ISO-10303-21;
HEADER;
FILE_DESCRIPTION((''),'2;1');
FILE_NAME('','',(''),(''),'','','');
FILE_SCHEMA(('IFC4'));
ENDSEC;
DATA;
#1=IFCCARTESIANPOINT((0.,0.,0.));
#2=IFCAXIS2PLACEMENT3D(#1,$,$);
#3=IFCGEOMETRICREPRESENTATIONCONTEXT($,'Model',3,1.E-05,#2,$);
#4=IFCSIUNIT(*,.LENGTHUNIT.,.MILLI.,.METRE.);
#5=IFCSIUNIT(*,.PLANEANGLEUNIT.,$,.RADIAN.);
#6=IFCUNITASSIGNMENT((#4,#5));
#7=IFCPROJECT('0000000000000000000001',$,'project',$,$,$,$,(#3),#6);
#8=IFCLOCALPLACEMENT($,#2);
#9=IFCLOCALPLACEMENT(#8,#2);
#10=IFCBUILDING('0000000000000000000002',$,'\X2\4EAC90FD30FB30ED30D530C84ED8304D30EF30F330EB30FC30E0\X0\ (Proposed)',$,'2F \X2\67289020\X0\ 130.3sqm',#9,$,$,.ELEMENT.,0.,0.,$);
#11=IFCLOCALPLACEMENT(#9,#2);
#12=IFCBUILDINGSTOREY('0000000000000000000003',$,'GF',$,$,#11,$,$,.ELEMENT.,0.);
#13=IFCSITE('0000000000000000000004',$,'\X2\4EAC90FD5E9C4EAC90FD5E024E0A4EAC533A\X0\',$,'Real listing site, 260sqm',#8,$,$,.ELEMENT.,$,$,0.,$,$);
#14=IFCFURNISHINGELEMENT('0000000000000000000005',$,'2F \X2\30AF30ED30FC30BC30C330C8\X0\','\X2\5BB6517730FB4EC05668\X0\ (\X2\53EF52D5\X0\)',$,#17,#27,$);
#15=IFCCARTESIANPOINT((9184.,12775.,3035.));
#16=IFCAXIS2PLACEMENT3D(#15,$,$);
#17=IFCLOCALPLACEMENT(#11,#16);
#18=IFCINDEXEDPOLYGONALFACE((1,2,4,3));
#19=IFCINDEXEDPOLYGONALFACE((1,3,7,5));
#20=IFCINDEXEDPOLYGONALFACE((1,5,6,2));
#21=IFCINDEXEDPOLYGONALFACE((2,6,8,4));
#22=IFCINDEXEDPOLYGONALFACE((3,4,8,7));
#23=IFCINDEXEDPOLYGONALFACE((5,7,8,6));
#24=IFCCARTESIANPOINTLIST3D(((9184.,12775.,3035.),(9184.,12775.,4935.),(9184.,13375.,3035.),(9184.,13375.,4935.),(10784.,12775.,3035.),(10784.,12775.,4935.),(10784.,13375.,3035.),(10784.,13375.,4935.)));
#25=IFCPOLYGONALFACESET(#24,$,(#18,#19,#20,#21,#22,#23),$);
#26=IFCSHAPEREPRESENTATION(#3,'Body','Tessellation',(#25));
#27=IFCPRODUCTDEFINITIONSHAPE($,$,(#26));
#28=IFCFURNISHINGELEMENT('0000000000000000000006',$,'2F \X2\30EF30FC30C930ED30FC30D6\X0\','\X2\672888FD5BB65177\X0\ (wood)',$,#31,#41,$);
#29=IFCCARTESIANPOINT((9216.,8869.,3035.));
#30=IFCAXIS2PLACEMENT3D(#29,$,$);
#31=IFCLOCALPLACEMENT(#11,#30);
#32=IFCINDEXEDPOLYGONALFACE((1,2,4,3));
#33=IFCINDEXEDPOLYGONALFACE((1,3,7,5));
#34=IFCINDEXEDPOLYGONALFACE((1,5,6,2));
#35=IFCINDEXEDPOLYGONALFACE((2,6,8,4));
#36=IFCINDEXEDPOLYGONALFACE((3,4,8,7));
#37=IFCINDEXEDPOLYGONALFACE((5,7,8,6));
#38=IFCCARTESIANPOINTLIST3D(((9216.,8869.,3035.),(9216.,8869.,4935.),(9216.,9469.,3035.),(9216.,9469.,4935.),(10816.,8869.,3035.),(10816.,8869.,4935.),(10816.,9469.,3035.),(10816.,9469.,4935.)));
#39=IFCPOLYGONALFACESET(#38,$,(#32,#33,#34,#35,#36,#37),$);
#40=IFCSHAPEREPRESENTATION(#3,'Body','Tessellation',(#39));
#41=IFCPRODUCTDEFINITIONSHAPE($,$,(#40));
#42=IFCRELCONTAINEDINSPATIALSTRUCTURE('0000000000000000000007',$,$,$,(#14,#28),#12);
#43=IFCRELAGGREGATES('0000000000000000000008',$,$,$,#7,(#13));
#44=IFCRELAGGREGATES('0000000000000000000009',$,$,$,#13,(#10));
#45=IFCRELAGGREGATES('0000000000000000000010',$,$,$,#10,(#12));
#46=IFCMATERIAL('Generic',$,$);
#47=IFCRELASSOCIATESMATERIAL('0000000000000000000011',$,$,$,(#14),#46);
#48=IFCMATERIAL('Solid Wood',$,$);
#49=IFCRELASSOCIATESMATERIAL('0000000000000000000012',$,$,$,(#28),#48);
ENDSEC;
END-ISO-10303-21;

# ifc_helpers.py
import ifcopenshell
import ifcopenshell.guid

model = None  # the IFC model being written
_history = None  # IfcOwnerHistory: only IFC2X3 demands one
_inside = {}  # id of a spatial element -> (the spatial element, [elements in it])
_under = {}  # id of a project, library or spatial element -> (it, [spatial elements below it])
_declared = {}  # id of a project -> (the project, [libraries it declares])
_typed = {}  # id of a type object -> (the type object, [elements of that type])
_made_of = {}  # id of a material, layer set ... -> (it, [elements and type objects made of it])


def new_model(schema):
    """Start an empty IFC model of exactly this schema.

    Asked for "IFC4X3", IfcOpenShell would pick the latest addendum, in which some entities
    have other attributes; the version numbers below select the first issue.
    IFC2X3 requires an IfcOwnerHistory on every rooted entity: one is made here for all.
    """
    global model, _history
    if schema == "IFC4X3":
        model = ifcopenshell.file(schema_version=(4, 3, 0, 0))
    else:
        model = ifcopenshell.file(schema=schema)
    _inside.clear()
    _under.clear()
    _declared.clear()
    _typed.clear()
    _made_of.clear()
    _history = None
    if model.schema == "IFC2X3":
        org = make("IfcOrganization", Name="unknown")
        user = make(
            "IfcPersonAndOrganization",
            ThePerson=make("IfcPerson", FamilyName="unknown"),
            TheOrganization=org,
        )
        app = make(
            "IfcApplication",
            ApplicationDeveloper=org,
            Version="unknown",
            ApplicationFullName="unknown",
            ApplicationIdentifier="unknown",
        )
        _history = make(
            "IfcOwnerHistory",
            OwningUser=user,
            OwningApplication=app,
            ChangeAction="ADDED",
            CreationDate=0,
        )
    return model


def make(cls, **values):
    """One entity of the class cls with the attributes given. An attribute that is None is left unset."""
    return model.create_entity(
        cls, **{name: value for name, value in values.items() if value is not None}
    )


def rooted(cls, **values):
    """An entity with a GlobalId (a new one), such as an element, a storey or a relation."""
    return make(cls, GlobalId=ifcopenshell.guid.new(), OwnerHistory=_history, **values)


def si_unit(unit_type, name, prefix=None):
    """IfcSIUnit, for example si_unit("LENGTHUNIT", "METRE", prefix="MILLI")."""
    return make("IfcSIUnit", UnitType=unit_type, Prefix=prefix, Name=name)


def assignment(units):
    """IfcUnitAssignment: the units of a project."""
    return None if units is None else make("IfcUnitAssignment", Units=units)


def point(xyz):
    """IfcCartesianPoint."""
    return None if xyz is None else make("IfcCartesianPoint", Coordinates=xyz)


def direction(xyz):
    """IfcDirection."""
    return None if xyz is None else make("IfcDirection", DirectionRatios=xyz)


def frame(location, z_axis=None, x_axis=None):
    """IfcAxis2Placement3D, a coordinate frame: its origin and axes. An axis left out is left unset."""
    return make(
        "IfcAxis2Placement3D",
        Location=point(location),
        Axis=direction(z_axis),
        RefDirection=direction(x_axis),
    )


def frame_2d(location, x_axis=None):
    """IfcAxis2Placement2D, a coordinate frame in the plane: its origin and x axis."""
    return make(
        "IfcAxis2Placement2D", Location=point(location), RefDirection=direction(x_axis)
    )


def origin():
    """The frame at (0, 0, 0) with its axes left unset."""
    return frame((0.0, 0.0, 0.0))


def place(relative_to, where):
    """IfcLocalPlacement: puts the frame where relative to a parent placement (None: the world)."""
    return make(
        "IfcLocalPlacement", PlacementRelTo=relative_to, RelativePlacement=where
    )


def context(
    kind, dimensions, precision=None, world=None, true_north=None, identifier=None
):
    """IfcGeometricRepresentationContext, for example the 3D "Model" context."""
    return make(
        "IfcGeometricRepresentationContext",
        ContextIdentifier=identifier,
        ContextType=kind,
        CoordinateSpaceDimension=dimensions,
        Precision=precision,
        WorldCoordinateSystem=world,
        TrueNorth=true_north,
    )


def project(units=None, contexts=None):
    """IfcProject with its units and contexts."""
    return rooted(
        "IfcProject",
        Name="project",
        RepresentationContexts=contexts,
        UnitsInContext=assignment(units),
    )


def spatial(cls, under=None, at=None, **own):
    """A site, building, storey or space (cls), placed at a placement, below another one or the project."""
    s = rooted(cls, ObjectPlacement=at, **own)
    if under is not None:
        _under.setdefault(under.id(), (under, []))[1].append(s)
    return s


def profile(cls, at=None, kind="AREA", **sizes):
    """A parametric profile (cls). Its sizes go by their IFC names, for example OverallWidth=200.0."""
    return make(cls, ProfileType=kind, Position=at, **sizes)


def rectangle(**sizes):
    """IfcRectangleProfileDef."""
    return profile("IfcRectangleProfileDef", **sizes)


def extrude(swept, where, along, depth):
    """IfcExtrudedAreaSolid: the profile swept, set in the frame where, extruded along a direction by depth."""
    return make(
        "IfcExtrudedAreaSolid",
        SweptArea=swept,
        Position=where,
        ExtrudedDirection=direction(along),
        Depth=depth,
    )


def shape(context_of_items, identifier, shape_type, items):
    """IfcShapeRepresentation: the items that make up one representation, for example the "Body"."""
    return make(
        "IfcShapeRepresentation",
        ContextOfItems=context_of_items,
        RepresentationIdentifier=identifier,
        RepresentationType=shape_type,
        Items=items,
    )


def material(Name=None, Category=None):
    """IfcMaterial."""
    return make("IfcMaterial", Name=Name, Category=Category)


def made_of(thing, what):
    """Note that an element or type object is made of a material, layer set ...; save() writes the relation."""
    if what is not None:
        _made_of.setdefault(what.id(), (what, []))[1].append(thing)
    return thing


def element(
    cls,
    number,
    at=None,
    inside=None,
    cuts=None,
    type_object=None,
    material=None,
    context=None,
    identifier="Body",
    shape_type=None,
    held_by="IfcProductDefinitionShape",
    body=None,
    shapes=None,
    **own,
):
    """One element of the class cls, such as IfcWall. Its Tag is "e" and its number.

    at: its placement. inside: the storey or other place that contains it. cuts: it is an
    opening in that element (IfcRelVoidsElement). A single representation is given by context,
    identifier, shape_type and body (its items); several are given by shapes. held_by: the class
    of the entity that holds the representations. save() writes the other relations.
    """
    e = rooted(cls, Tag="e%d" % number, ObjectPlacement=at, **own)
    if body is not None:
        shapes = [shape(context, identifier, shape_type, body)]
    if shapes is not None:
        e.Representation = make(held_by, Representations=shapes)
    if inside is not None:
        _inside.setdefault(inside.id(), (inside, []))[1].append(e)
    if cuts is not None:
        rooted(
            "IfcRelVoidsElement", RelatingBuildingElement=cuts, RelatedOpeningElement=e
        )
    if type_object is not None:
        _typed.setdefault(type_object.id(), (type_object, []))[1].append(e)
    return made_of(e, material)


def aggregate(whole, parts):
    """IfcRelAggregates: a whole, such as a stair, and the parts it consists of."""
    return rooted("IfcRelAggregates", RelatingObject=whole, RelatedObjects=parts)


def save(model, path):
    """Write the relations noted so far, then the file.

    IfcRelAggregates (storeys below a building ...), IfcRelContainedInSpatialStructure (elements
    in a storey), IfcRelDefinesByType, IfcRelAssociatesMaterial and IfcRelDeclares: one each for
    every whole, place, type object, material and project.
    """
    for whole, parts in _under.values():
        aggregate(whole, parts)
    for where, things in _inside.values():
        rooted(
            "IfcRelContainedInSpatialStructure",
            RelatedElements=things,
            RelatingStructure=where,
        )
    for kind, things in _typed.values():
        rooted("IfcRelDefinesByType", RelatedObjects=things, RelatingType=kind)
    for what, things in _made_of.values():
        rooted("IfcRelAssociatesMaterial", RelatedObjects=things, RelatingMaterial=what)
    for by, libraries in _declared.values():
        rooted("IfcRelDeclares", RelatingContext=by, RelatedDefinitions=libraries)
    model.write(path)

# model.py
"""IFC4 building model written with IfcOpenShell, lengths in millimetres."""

from ifc_helpers import new_model, si_unit, frame, frame_2d, origin, place, context, project, spatial, rectangle, extrude, material, element, save


model = new_model("IFC4")

# Units and contexts
model_context = context("Model", 3, precision=1e-05, world=origin())
ifc_project = project(units=[si_unit("LENGTHUNIT", "METRE", prefix="MILLI"), si_unit("PLANEANGLEUNIT", "RADIAN")], contexts=[model_context])

# Site, building, storey
site_placement = place(None, origin())
site = spatial("IfcSite", under=ifc_project, at=site_placement, Name="京都府京都市上京区", ObjectType="Real listing site, 260sqm", CompositionType="ELEMENT", RefElevation=0.0)
building_placement = place(site_placement, origin())
building = spatial("IfcBuilding", under=site, at=building_placement, Name="京都・ロフト付きワンルーム (Proposed)", ObjectType="2F 木造 130.3sqm", CompositionType="ELEMENT", ElevationOfRefHeight=0.0, ElevationOfTerrain=0.0)
storey_placement = place(building_placement, origin())
storey = spatial("IfcBuildingStorey", under=building, at=storey_placement, Name="GF", CompositionType="ELEMENT", Elevation=0.0)

# Shared definitions
ifc_material_1 = material(Name="Solid Wood")

# Shared definitions
ifc_material_2 = material(Name="Generic")

# Furnishing elements
furnishing_1_placement = place(storey_placement, frame((9184.0, 12775.0, 3035.0)))
element("IfcFurnishingElement", 1, at=furnishing_1_placement, inside=storey, material=ifc_material_2, Name="2F クローゼット", Description="家具・什器 (可動)", context=model_context, shape_type="SweptSolid", body=[
    extrude(rectangle(XDim=1600.0, YDim=600.0, at=frame_2d((800.0, 300.0))), frame((9184.0, 12775.0, 3035.0)), (0.0, 0.0, 1.0), 1900.0),
])
furnishing_2_placement = place(storey_placement, frame((9216.0, 8869.0, 3035.0)))
element("IfcFurnishingElement", 2, at=furnishing_2_placement, inside=storey, material=ifc_material_1, Name="2F ワードローブ", Description="木製家具 (wood)", context=model_context, shape_type="SweptSolid", body=[
    extrude(rectangle(XDim=1600.0, YDim=600.0, at=frame_2d((800.0, 300.0))), frame((9216.0, 8869.0, 3035.0)), (0.0, 0.0, 1.0), 1900.0),
])

save(model, "model.ifc")
